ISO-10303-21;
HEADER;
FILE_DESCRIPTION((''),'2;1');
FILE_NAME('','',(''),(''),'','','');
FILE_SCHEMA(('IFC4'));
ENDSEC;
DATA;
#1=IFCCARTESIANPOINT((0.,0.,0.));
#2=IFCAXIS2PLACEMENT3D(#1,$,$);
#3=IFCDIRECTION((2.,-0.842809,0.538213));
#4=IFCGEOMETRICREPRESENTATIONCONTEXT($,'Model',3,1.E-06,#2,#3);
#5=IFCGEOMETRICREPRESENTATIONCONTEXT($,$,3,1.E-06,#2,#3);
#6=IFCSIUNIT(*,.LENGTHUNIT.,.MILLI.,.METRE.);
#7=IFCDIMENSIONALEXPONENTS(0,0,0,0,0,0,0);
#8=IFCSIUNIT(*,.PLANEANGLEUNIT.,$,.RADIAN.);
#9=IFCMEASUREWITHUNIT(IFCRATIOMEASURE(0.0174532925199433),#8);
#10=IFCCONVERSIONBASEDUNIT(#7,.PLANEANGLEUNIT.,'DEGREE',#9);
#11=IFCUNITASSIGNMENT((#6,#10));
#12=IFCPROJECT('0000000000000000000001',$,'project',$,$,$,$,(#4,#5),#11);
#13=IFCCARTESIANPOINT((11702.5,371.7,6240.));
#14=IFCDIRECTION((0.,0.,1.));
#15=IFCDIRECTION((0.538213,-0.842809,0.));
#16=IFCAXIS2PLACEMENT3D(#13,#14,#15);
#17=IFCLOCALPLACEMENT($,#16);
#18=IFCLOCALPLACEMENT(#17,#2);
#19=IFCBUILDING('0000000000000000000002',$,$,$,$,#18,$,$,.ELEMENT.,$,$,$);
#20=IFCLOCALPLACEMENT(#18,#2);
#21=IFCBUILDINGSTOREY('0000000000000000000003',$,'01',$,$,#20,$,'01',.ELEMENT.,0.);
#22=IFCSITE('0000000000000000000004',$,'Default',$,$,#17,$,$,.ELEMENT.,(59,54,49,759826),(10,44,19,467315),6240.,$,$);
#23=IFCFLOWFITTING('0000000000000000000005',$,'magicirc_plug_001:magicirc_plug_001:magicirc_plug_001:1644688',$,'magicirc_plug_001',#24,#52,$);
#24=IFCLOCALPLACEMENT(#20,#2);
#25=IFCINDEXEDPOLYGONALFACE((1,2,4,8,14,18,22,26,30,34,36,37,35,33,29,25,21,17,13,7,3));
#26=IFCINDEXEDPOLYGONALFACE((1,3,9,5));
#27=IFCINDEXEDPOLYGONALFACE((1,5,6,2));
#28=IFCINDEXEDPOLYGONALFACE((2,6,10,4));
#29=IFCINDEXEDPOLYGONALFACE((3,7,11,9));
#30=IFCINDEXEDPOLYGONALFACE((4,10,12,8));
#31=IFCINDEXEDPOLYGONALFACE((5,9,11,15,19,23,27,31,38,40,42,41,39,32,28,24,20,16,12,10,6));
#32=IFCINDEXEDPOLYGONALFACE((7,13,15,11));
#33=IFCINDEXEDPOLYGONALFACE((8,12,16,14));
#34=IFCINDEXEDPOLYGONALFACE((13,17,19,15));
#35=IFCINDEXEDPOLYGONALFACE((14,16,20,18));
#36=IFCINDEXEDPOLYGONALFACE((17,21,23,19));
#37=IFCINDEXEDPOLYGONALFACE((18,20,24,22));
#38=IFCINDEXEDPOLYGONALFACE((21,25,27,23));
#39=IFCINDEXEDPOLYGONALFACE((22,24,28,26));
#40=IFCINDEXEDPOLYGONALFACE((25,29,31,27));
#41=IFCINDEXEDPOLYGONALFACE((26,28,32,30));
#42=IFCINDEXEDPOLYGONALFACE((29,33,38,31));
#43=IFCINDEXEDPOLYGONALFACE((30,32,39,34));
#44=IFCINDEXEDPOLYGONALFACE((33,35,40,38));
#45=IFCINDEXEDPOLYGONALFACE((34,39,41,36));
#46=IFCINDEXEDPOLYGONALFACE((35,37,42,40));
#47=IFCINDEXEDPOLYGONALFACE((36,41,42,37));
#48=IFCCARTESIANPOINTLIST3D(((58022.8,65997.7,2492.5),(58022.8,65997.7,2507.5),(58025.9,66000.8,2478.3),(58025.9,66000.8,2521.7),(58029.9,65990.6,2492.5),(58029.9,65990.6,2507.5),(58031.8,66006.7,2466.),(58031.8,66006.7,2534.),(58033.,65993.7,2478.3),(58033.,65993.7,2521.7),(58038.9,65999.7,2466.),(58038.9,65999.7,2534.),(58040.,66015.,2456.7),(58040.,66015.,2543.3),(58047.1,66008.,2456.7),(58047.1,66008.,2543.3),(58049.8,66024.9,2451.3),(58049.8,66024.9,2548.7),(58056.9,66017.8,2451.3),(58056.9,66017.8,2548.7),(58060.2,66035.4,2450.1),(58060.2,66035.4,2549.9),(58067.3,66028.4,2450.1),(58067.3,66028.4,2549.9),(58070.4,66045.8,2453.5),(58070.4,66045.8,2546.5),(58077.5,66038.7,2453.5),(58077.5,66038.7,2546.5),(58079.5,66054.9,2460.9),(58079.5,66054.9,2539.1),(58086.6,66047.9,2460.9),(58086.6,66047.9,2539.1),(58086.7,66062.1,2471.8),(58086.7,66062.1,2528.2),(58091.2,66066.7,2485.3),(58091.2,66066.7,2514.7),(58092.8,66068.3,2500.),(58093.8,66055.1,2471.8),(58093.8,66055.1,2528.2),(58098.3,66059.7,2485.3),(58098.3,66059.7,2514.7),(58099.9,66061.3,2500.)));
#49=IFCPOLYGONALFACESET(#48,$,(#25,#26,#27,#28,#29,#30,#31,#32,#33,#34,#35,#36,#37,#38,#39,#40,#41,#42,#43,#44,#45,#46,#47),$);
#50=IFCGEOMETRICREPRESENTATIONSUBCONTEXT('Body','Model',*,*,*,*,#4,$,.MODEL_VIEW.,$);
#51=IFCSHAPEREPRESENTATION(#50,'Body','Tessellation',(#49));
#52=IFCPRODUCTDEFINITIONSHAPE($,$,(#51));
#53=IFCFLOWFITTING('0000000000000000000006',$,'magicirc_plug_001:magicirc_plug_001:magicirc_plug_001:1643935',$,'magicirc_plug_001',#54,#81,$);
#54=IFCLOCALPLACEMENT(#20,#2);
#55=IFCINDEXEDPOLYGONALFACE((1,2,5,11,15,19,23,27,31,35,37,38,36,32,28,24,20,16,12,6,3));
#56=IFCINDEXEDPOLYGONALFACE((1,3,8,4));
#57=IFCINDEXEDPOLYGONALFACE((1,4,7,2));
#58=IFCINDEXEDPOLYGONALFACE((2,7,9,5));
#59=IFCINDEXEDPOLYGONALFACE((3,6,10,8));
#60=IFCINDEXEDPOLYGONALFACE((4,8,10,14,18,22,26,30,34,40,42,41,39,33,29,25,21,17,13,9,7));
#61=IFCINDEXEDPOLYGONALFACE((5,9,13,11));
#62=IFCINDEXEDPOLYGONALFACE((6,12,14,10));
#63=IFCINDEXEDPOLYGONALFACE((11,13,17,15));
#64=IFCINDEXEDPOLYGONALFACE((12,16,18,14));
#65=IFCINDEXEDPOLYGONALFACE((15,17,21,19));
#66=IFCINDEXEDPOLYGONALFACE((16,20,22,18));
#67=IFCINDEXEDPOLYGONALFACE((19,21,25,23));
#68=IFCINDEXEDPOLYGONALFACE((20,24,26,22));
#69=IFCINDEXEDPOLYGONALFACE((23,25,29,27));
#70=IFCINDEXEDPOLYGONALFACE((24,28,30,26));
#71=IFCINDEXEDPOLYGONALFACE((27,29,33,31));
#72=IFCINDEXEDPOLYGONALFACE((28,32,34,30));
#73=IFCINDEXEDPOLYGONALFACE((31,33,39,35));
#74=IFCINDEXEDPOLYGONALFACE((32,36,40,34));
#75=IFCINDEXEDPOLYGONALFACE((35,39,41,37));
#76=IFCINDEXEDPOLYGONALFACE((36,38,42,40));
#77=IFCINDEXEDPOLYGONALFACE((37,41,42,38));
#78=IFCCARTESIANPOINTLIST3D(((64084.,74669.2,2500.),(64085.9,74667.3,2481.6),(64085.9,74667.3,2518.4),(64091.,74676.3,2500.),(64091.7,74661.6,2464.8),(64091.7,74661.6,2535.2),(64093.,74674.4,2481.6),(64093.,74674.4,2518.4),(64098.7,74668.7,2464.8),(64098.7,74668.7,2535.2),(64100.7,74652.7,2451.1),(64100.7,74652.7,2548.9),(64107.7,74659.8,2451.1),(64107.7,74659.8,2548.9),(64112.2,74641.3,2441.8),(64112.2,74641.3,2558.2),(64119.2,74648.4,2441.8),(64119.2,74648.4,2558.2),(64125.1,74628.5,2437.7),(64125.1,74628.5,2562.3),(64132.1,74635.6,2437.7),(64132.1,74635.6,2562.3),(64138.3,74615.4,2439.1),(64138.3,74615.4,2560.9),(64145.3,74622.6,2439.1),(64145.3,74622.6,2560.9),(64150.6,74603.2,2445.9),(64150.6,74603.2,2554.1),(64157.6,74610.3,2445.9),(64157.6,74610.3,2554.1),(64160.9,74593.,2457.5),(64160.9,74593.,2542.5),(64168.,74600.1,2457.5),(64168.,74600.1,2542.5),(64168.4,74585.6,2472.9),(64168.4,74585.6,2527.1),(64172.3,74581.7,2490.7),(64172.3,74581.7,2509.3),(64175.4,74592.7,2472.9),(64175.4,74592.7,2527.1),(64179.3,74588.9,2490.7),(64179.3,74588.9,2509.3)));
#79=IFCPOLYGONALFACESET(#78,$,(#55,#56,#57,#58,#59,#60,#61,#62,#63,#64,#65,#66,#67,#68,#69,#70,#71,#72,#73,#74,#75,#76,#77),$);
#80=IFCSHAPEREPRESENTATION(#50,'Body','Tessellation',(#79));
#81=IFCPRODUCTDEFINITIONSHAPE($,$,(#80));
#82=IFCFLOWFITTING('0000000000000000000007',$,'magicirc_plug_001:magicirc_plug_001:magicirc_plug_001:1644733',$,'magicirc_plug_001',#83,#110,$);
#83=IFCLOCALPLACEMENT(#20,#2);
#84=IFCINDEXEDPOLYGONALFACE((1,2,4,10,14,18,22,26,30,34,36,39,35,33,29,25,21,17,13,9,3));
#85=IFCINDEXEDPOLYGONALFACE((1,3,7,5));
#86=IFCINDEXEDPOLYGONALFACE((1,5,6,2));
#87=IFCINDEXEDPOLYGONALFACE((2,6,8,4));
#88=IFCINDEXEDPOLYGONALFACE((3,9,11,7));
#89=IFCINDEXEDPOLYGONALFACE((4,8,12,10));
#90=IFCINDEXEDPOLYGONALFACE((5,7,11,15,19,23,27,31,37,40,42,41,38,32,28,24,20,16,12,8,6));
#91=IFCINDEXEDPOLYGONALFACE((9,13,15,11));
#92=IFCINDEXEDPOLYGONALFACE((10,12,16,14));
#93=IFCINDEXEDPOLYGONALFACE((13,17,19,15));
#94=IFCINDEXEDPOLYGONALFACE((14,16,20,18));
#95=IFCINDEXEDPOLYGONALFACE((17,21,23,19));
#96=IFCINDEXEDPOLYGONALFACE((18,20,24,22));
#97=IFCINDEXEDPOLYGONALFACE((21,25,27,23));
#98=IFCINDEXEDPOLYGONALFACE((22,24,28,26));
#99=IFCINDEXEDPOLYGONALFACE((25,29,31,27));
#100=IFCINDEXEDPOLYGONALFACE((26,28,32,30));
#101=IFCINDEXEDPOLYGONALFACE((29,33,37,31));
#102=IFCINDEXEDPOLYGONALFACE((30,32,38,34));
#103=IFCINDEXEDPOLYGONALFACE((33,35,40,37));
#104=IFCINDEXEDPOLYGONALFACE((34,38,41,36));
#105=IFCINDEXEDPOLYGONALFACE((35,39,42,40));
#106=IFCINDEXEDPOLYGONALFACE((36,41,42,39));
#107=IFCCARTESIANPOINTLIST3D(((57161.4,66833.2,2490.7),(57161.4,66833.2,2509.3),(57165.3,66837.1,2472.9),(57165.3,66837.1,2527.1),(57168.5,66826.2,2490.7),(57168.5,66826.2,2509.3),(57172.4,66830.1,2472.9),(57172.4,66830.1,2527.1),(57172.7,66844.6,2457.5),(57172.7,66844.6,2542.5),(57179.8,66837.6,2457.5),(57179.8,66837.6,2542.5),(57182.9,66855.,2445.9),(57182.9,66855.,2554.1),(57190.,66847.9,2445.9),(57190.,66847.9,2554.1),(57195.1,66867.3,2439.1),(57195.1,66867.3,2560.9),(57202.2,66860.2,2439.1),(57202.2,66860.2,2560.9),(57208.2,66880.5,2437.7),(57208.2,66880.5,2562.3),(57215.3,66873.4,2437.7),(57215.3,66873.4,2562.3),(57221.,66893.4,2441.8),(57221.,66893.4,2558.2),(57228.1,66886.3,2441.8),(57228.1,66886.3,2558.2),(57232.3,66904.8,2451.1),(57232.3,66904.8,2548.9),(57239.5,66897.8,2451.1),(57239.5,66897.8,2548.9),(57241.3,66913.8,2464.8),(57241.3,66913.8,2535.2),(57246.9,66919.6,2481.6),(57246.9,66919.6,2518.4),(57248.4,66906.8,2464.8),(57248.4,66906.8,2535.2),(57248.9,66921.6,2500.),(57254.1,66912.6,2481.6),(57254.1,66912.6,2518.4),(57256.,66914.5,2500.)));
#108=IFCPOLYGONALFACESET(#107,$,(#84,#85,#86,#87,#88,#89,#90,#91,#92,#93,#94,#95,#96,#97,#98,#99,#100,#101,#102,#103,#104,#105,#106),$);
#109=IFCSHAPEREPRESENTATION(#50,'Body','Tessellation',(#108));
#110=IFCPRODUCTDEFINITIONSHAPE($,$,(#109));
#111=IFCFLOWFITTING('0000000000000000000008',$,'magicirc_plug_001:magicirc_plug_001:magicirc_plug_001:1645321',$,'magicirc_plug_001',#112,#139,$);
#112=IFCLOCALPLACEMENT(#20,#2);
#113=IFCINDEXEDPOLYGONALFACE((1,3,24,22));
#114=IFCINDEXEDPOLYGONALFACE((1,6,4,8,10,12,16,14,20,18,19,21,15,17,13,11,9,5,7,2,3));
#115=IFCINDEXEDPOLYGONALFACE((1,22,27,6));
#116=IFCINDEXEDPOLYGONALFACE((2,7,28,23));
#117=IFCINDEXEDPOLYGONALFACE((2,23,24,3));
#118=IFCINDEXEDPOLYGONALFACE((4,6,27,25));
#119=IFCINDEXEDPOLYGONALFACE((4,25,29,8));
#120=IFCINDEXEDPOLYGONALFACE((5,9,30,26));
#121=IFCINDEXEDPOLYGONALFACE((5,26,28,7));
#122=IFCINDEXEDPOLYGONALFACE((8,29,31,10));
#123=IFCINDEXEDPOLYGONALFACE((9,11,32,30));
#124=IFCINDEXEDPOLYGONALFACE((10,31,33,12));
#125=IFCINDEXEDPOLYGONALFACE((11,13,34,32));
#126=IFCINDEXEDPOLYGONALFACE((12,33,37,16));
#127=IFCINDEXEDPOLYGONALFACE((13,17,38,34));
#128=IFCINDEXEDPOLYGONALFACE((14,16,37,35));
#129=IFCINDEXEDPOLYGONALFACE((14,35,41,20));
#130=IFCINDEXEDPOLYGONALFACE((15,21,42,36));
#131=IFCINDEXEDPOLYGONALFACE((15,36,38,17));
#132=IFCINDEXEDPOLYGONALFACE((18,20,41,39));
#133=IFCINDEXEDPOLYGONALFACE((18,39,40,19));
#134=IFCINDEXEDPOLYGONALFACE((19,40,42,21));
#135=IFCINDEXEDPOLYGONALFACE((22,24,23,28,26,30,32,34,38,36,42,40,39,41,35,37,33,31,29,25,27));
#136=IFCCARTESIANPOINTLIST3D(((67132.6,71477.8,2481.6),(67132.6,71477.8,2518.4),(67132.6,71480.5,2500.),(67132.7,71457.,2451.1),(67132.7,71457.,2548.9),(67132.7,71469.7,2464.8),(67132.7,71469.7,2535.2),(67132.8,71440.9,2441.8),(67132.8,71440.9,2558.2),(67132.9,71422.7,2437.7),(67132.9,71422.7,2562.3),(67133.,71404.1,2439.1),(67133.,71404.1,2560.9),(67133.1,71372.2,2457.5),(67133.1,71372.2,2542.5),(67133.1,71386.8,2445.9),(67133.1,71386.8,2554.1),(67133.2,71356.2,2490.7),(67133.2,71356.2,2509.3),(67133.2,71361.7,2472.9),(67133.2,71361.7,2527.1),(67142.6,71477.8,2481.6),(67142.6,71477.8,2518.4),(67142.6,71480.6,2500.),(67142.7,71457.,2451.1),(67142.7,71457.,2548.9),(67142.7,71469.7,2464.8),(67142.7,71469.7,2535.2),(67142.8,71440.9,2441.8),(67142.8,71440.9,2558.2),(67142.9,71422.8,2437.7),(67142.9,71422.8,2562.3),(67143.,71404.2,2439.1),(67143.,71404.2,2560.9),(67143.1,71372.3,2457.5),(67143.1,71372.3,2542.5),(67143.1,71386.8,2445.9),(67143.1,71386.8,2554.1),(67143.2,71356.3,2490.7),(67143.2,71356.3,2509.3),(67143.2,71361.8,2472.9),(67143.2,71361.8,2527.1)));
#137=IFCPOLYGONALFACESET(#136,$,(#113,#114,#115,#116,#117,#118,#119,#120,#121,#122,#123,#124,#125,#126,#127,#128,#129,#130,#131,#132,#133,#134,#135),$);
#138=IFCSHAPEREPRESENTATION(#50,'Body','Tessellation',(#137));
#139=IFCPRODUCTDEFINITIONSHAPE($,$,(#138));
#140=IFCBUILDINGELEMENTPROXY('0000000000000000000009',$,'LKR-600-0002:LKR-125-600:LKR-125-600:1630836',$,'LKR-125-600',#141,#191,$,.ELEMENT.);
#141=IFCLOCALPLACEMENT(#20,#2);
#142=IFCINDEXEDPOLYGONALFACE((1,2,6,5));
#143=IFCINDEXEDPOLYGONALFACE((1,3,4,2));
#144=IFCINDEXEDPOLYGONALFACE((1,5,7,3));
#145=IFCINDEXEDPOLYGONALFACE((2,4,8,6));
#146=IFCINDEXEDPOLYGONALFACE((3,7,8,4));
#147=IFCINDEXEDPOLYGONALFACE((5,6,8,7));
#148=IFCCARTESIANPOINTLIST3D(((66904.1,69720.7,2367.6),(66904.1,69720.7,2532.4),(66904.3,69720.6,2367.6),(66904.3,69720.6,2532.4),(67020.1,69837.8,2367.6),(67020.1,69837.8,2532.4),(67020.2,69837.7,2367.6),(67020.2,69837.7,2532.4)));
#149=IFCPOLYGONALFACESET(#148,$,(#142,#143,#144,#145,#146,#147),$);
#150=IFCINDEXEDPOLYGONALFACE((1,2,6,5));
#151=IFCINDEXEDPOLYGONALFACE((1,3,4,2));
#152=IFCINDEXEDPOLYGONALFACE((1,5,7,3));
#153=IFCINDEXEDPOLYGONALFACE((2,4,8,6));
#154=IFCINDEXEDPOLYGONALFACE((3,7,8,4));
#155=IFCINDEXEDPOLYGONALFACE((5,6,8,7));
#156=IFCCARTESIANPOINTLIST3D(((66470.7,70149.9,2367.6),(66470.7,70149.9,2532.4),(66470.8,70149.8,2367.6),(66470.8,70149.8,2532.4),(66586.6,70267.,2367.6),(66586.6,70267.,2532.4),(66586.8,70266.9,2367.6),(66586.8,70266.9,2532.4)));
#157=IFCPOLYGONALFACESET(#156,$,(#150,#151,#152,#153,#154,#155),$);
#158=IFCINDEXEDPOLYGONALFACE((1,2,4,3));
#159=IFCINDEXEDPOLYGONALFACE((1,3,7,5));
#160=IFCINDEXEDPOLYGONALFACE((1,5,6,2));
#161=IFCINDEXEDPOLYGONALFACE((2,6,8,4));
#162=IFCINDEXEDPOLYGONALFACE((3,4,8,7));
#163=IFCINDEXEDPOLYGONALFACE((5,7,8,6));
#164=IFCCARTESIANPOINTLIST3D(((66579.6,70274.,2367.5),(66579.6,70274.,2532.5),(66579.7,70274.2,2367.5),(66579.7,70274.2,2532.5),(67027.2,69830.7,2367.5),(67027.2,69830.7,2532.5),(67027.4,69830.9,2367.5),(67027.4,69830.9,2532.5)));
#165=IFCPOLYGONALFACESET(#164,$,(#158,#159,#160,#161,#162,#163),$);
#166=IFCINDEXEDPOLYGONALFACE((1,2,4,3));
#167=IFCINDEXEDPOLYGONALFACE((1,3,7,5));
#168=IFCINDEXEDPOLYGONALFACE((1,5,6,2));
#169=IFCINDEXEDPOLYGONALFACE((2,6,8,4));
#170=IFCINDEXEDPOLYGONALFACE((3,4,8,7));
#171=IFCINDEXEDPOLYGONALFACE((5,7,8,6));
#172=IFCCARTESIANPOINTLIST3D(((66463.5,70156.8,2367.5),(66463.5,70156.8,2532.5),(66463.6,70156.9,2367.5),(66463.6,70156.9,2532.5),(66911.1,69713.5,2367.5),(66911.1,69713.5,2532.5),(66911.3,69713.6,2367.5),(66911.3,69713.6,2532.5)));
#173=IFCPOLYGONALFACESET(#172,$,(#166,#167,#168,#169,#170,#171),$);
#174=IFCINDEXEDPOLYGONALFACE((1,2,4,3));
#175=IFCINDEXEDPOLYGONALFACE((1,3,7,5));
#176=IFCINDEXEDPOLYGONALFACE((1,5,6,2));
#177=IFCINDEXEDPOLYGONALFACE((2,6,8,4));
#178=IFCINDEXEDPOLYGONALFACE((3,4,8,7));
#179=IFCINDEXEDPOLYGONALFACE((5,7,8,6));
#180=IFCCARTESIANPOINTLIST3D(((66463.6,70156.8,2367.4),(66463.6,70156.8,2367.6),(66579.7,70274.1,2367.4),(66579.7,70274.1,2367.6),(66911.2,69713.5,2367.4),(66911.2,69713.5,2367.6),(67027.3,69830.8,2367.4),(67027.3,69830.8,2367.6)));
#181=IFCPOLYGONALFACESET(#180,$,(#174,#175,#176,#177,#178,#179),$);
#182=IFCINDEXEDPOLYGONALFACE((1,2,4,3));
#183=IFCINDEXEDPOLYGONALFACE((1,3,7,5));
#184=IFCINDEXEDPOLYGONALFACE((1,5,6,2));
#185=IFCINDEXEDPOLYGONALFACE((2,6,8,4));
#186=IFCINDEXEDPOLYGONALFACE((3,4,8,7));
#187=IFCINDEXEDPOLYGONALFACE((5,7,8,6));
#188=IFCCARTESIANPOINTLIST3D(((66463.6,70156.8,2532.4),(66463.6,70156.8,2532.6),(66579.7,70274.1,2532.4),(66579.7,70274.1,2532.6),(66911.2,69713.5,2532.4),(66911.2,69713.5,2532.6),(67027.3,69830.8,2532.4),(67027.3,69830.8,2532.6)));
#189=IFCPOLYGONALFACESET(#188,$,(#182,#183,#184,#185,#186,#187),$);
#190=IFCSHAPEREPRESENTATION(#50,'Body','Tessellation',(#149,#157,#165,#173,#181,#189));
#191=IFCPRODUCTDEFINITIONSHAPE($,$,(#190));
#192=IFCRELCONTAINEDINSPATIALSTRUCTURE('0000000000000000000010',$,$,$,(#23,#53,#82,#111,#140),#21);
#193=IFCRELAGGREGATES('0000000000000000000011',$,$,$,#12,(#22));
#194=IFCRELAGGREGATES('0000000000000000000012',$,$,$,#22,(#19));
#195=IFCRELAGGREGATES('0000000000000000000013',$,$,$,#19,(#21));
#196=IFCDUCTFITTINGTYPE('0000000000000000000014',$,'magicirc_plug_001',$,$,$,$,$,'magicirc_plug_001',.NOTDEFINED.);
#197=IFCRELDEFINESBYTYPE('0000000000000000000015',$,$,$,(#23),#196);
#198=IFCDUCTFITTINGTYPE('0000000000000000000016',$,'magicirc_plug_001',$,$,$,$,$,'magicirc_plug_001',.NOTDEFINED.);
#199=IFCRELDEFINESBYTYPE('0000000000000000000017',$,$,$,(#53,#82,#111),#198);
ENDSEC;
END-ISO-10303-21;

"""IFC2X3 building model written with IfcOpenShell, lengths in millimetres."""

from ifc_helpers import new_model, entity, si_unit, converted_unit, direction, frame, frame_2d, origin, place, context, subcontext, project, spatial, rectangle, circle, extrude, source, transform, mapped, type_object, type_shapes, element, save


model = new_model("IFC2X3")

# Units and contexts
model_context = context("Model", 3, precision=1e-06, world=origin(), true_north=direction((2.0, -0.842809, 0.538213)))
context_of_model = context(None, 3, precision=1e-06, world=origin(), true_north=direction((2.0, -0.842809, 0.538213)))
body_context = subcontext(model_context, "Body", "Model", "MODEL_VIEW")
ifc_project = project(units=[si_unit("LENGTHUNIT", "METRE", prefix="MILLI"), converted_unit("PLANEANGLEUNIT", "DEGREE", entity("IfcRatioMeasure", 0.0174532925199433), si_unit("PLANEANGLEUNIT", "RADIAN"), dimensions=[0, 0, 0, 0, 0, 0, 0])], contexts=[model_context, context_of_model])

# Site, building, storey
site_placement = place(None, frame((11702.5, 371.7, 6240.0), z_axis=(0.0, 0.0, 1.0), x_axis=(0.538213, -0.842809, 0.0)))
site = spatial("IfcSite", under=ifc_project, at=site_placement, Name="Default", CompositionType="ELEMENT", RefLatitude=(59, 54, 49, 759826), RefLongitude=(10, 44, 19, 467315), RefElevation=6240.0)
building_placement = place(site_placement, origin())
building = spatial("IfcBuilding", under=site, at=building_placement, CompositionType="ELEMENT")
storey_placement = place(building_placement, origin())
storey = spatial("IfcBuildingStorey", under=building, at=storey_placement, Name="01", LongName="01", CompositionType="ELEMENT", Elevation=0.0)

# Flow fittings
duct_fitting_type_1 = type_object("IfcDuctFittingType", Name="magicirc_plug_001", ElementType="magicirc_plug_001", PredefinedType="NOTDEFINED")
shared_shape_1 = source(origin(), body_context, "Body", "SweptSolid", [
    extrude(circle(Radius=50.0, at=frame_2d((0.0, 0.0), x_axis=(1.0, 0.0))), frame((0.0, 0.0, 0.0), z_axis=(1.0, 0.0, 0.0), x_axis=(0.0, 1.0, 0.0)), (0.0, 0.0, 1.0), 10.0),
])
type_shapes(duct_fitting_type_1, [shared_shape_1])
for number, where, z_axis, x_axis, name in (
    (1, (58057.6, 66032.8, 2500.0), (0.0, 0.0, 1.0), (0.710554, -0.703643, 0.0), "magicirc_plug_001:magicirc_plug_001:magicirc_plug_001:1644688"),
):
    element("IfcFlowFitting", number, at=place(storey_placement, frame(where, z_axis=z_axis, x_axis=x_axis)), inside=storey, type_object=duct_fitting_type_1, Name=name, ObjectType="magicirc_plug_001", context=body_context, shape_type="MappedRepresentation", body=[
        mapped(shared_shape_1, transform((0.0, 0.0, 0.0), scale=1.0)),
    ])
duct_fitting_type_2 = type_object("IfcDuctFittingType", Name="magicirc_plug_001", ElementType="magicirc_plug_001", PredefinedType="NOTDEFINED")
shared_shape_2 = source(origin(), body_context, "Body", "SweptSolid", [
    extrude(circle(Radius=62.5, at=frame_2d((0.0, 0.0), x_axis=(1.0, 0.0))), frame((0.0, 0.0, 0.0), z_axis=(1.0, 0.0, 0.0), x_axis=(0.0, 1.0, 0.0)), (0.0, 0.0, 1.0), 10.0),
])
type_shapes(duct_fitting_type_2, [shared_shape_2])
for number, where, z_axis, x_axis, name in (
    (2, (64128.4, 74625.2, 2500.0), (0.0, 0.0, 1.0), (0.703643, 0.710554, 0.0), "magicirc_plug_001:magicirc_plug_001:magicirc_plug_001:1643935"),
    (3, (57204.9, 66877.2, 2500.0), (0.0, 0.0, 1.0), (0.710554, -0.703643, 0.0), "magicirc_plug_001:magicirc_plug_001:magicirc_plug_001:1644733"),
    (4, (67132.9, 71418.0, 2500.0), (0.0, 0.0, 1.0), (0.999988, 0.004887, 0.0), "magicirc_plug_001:magicirc_plug_001:magicirc_plug_001:1645321"),
):
    element("IfcFlowFitting", number, at=place(storey_placement, frame(where, z_axis=z_axis, x_axis=x_axis)), inside=storey, type_object=duct_fitting_type_2, Name=name, ObjectType="magicirc_plug_001", context=body_context, shape_type="MappedRepresentation", body=[
        mapped(shared_shape_2, transform((0.0, 0.0, 0.0), scale=1.0)),
    ])

# Building element proxy
shared_shape_3 = source(origin(), body_context, "Body", "SweptSolid", [
    extrude(rectangle(XDim=0.2, YDim=164.8, at=frame_2d((0.0, 0.0), x_axis=(1.0, 0.0))), frame((305.0, 0.0, -82.4)), (0.0, 0.0, 1.0), 164.8),
    extrude(rectangle(XDim=0.2, YDim=164.8, at=frame_2d((0.0, 0.0), x_axis=(1.0, 0.0))), frame((-305.0, 0.0, -82.4)), (0.0, 0.0, 1.0), 164.8),
    extrude(rectangle(XDim=0.2, YDim=630.0, at=frame_2d((0.0, 0.0), x_axis=(1.0, 0.0))), frame((0.0, 82.5, -82.5), z_axis=(0.0, 0.0, 1.0), x_axis=(0.0, 1.0, 0.0)), (0.0, 0.0, 1.0), 165.0),
    extrude(rectangle(XDim=0.2, YDim=630.0, at=frame_2d((0.0, 0.0), x_axis=(1.0, 0.0))), frame((0.0, -82.5, -82.5), z_axis=(0.0, 0.0, 1.0), x_axis=(0.0, 1.0, 0.0)), (0.0, 0.0, 1.0), 165.0),
    extrude(rectangle(XDim=165.0, YDim=630.0, at=frame_2d((0.0, 0.0), x_axis=(1.0, 0.0))), frame((0.0, 0.0, -82.6), z_axis=(0.0, 0.0, 1.0), x_axis=(0.0, -1.0, 0.0)), (0.0, 0.0, 1.0), 0.2),
    extrude(rectangle(XDim=165.0, YDim=630.0, at=frame_2d((0.0, 0.0), x_axis=(1.0, 0.0))), frame((0.0, 0.0, 82.4), z_axis=(0.0, 0.0, 1.0), x_axis=(0.0, -1.0, 0.0)), (0.0, 0.0, 1.0), 0.2),
])
for number, where, z_axis, x_axis, name in (
    (5, (66745.4, 69993.8, 2450.0), (0.0, 0.0, 1.0), (0.710554, -0.703643, 0.0), "LKR-600-0002:LKR-125-600:LKR-125-600:1630836"),
):
    element("IfcBuildingElementProxy", number, at=place(storey_placement, frame(where, z_axis=z_axis, x_axis=x_axis)), inside=storey, Name=name, ObjectType="LKR-125-600", CompositionType="ELEMENT", context=body_context, shape_type="MappedRepresentation", body=[
        mapped(shared_shape_3, transform((0.0, 0.0, 0.0), scale=1.0)),
    ])

save(model, "model.ifc")
